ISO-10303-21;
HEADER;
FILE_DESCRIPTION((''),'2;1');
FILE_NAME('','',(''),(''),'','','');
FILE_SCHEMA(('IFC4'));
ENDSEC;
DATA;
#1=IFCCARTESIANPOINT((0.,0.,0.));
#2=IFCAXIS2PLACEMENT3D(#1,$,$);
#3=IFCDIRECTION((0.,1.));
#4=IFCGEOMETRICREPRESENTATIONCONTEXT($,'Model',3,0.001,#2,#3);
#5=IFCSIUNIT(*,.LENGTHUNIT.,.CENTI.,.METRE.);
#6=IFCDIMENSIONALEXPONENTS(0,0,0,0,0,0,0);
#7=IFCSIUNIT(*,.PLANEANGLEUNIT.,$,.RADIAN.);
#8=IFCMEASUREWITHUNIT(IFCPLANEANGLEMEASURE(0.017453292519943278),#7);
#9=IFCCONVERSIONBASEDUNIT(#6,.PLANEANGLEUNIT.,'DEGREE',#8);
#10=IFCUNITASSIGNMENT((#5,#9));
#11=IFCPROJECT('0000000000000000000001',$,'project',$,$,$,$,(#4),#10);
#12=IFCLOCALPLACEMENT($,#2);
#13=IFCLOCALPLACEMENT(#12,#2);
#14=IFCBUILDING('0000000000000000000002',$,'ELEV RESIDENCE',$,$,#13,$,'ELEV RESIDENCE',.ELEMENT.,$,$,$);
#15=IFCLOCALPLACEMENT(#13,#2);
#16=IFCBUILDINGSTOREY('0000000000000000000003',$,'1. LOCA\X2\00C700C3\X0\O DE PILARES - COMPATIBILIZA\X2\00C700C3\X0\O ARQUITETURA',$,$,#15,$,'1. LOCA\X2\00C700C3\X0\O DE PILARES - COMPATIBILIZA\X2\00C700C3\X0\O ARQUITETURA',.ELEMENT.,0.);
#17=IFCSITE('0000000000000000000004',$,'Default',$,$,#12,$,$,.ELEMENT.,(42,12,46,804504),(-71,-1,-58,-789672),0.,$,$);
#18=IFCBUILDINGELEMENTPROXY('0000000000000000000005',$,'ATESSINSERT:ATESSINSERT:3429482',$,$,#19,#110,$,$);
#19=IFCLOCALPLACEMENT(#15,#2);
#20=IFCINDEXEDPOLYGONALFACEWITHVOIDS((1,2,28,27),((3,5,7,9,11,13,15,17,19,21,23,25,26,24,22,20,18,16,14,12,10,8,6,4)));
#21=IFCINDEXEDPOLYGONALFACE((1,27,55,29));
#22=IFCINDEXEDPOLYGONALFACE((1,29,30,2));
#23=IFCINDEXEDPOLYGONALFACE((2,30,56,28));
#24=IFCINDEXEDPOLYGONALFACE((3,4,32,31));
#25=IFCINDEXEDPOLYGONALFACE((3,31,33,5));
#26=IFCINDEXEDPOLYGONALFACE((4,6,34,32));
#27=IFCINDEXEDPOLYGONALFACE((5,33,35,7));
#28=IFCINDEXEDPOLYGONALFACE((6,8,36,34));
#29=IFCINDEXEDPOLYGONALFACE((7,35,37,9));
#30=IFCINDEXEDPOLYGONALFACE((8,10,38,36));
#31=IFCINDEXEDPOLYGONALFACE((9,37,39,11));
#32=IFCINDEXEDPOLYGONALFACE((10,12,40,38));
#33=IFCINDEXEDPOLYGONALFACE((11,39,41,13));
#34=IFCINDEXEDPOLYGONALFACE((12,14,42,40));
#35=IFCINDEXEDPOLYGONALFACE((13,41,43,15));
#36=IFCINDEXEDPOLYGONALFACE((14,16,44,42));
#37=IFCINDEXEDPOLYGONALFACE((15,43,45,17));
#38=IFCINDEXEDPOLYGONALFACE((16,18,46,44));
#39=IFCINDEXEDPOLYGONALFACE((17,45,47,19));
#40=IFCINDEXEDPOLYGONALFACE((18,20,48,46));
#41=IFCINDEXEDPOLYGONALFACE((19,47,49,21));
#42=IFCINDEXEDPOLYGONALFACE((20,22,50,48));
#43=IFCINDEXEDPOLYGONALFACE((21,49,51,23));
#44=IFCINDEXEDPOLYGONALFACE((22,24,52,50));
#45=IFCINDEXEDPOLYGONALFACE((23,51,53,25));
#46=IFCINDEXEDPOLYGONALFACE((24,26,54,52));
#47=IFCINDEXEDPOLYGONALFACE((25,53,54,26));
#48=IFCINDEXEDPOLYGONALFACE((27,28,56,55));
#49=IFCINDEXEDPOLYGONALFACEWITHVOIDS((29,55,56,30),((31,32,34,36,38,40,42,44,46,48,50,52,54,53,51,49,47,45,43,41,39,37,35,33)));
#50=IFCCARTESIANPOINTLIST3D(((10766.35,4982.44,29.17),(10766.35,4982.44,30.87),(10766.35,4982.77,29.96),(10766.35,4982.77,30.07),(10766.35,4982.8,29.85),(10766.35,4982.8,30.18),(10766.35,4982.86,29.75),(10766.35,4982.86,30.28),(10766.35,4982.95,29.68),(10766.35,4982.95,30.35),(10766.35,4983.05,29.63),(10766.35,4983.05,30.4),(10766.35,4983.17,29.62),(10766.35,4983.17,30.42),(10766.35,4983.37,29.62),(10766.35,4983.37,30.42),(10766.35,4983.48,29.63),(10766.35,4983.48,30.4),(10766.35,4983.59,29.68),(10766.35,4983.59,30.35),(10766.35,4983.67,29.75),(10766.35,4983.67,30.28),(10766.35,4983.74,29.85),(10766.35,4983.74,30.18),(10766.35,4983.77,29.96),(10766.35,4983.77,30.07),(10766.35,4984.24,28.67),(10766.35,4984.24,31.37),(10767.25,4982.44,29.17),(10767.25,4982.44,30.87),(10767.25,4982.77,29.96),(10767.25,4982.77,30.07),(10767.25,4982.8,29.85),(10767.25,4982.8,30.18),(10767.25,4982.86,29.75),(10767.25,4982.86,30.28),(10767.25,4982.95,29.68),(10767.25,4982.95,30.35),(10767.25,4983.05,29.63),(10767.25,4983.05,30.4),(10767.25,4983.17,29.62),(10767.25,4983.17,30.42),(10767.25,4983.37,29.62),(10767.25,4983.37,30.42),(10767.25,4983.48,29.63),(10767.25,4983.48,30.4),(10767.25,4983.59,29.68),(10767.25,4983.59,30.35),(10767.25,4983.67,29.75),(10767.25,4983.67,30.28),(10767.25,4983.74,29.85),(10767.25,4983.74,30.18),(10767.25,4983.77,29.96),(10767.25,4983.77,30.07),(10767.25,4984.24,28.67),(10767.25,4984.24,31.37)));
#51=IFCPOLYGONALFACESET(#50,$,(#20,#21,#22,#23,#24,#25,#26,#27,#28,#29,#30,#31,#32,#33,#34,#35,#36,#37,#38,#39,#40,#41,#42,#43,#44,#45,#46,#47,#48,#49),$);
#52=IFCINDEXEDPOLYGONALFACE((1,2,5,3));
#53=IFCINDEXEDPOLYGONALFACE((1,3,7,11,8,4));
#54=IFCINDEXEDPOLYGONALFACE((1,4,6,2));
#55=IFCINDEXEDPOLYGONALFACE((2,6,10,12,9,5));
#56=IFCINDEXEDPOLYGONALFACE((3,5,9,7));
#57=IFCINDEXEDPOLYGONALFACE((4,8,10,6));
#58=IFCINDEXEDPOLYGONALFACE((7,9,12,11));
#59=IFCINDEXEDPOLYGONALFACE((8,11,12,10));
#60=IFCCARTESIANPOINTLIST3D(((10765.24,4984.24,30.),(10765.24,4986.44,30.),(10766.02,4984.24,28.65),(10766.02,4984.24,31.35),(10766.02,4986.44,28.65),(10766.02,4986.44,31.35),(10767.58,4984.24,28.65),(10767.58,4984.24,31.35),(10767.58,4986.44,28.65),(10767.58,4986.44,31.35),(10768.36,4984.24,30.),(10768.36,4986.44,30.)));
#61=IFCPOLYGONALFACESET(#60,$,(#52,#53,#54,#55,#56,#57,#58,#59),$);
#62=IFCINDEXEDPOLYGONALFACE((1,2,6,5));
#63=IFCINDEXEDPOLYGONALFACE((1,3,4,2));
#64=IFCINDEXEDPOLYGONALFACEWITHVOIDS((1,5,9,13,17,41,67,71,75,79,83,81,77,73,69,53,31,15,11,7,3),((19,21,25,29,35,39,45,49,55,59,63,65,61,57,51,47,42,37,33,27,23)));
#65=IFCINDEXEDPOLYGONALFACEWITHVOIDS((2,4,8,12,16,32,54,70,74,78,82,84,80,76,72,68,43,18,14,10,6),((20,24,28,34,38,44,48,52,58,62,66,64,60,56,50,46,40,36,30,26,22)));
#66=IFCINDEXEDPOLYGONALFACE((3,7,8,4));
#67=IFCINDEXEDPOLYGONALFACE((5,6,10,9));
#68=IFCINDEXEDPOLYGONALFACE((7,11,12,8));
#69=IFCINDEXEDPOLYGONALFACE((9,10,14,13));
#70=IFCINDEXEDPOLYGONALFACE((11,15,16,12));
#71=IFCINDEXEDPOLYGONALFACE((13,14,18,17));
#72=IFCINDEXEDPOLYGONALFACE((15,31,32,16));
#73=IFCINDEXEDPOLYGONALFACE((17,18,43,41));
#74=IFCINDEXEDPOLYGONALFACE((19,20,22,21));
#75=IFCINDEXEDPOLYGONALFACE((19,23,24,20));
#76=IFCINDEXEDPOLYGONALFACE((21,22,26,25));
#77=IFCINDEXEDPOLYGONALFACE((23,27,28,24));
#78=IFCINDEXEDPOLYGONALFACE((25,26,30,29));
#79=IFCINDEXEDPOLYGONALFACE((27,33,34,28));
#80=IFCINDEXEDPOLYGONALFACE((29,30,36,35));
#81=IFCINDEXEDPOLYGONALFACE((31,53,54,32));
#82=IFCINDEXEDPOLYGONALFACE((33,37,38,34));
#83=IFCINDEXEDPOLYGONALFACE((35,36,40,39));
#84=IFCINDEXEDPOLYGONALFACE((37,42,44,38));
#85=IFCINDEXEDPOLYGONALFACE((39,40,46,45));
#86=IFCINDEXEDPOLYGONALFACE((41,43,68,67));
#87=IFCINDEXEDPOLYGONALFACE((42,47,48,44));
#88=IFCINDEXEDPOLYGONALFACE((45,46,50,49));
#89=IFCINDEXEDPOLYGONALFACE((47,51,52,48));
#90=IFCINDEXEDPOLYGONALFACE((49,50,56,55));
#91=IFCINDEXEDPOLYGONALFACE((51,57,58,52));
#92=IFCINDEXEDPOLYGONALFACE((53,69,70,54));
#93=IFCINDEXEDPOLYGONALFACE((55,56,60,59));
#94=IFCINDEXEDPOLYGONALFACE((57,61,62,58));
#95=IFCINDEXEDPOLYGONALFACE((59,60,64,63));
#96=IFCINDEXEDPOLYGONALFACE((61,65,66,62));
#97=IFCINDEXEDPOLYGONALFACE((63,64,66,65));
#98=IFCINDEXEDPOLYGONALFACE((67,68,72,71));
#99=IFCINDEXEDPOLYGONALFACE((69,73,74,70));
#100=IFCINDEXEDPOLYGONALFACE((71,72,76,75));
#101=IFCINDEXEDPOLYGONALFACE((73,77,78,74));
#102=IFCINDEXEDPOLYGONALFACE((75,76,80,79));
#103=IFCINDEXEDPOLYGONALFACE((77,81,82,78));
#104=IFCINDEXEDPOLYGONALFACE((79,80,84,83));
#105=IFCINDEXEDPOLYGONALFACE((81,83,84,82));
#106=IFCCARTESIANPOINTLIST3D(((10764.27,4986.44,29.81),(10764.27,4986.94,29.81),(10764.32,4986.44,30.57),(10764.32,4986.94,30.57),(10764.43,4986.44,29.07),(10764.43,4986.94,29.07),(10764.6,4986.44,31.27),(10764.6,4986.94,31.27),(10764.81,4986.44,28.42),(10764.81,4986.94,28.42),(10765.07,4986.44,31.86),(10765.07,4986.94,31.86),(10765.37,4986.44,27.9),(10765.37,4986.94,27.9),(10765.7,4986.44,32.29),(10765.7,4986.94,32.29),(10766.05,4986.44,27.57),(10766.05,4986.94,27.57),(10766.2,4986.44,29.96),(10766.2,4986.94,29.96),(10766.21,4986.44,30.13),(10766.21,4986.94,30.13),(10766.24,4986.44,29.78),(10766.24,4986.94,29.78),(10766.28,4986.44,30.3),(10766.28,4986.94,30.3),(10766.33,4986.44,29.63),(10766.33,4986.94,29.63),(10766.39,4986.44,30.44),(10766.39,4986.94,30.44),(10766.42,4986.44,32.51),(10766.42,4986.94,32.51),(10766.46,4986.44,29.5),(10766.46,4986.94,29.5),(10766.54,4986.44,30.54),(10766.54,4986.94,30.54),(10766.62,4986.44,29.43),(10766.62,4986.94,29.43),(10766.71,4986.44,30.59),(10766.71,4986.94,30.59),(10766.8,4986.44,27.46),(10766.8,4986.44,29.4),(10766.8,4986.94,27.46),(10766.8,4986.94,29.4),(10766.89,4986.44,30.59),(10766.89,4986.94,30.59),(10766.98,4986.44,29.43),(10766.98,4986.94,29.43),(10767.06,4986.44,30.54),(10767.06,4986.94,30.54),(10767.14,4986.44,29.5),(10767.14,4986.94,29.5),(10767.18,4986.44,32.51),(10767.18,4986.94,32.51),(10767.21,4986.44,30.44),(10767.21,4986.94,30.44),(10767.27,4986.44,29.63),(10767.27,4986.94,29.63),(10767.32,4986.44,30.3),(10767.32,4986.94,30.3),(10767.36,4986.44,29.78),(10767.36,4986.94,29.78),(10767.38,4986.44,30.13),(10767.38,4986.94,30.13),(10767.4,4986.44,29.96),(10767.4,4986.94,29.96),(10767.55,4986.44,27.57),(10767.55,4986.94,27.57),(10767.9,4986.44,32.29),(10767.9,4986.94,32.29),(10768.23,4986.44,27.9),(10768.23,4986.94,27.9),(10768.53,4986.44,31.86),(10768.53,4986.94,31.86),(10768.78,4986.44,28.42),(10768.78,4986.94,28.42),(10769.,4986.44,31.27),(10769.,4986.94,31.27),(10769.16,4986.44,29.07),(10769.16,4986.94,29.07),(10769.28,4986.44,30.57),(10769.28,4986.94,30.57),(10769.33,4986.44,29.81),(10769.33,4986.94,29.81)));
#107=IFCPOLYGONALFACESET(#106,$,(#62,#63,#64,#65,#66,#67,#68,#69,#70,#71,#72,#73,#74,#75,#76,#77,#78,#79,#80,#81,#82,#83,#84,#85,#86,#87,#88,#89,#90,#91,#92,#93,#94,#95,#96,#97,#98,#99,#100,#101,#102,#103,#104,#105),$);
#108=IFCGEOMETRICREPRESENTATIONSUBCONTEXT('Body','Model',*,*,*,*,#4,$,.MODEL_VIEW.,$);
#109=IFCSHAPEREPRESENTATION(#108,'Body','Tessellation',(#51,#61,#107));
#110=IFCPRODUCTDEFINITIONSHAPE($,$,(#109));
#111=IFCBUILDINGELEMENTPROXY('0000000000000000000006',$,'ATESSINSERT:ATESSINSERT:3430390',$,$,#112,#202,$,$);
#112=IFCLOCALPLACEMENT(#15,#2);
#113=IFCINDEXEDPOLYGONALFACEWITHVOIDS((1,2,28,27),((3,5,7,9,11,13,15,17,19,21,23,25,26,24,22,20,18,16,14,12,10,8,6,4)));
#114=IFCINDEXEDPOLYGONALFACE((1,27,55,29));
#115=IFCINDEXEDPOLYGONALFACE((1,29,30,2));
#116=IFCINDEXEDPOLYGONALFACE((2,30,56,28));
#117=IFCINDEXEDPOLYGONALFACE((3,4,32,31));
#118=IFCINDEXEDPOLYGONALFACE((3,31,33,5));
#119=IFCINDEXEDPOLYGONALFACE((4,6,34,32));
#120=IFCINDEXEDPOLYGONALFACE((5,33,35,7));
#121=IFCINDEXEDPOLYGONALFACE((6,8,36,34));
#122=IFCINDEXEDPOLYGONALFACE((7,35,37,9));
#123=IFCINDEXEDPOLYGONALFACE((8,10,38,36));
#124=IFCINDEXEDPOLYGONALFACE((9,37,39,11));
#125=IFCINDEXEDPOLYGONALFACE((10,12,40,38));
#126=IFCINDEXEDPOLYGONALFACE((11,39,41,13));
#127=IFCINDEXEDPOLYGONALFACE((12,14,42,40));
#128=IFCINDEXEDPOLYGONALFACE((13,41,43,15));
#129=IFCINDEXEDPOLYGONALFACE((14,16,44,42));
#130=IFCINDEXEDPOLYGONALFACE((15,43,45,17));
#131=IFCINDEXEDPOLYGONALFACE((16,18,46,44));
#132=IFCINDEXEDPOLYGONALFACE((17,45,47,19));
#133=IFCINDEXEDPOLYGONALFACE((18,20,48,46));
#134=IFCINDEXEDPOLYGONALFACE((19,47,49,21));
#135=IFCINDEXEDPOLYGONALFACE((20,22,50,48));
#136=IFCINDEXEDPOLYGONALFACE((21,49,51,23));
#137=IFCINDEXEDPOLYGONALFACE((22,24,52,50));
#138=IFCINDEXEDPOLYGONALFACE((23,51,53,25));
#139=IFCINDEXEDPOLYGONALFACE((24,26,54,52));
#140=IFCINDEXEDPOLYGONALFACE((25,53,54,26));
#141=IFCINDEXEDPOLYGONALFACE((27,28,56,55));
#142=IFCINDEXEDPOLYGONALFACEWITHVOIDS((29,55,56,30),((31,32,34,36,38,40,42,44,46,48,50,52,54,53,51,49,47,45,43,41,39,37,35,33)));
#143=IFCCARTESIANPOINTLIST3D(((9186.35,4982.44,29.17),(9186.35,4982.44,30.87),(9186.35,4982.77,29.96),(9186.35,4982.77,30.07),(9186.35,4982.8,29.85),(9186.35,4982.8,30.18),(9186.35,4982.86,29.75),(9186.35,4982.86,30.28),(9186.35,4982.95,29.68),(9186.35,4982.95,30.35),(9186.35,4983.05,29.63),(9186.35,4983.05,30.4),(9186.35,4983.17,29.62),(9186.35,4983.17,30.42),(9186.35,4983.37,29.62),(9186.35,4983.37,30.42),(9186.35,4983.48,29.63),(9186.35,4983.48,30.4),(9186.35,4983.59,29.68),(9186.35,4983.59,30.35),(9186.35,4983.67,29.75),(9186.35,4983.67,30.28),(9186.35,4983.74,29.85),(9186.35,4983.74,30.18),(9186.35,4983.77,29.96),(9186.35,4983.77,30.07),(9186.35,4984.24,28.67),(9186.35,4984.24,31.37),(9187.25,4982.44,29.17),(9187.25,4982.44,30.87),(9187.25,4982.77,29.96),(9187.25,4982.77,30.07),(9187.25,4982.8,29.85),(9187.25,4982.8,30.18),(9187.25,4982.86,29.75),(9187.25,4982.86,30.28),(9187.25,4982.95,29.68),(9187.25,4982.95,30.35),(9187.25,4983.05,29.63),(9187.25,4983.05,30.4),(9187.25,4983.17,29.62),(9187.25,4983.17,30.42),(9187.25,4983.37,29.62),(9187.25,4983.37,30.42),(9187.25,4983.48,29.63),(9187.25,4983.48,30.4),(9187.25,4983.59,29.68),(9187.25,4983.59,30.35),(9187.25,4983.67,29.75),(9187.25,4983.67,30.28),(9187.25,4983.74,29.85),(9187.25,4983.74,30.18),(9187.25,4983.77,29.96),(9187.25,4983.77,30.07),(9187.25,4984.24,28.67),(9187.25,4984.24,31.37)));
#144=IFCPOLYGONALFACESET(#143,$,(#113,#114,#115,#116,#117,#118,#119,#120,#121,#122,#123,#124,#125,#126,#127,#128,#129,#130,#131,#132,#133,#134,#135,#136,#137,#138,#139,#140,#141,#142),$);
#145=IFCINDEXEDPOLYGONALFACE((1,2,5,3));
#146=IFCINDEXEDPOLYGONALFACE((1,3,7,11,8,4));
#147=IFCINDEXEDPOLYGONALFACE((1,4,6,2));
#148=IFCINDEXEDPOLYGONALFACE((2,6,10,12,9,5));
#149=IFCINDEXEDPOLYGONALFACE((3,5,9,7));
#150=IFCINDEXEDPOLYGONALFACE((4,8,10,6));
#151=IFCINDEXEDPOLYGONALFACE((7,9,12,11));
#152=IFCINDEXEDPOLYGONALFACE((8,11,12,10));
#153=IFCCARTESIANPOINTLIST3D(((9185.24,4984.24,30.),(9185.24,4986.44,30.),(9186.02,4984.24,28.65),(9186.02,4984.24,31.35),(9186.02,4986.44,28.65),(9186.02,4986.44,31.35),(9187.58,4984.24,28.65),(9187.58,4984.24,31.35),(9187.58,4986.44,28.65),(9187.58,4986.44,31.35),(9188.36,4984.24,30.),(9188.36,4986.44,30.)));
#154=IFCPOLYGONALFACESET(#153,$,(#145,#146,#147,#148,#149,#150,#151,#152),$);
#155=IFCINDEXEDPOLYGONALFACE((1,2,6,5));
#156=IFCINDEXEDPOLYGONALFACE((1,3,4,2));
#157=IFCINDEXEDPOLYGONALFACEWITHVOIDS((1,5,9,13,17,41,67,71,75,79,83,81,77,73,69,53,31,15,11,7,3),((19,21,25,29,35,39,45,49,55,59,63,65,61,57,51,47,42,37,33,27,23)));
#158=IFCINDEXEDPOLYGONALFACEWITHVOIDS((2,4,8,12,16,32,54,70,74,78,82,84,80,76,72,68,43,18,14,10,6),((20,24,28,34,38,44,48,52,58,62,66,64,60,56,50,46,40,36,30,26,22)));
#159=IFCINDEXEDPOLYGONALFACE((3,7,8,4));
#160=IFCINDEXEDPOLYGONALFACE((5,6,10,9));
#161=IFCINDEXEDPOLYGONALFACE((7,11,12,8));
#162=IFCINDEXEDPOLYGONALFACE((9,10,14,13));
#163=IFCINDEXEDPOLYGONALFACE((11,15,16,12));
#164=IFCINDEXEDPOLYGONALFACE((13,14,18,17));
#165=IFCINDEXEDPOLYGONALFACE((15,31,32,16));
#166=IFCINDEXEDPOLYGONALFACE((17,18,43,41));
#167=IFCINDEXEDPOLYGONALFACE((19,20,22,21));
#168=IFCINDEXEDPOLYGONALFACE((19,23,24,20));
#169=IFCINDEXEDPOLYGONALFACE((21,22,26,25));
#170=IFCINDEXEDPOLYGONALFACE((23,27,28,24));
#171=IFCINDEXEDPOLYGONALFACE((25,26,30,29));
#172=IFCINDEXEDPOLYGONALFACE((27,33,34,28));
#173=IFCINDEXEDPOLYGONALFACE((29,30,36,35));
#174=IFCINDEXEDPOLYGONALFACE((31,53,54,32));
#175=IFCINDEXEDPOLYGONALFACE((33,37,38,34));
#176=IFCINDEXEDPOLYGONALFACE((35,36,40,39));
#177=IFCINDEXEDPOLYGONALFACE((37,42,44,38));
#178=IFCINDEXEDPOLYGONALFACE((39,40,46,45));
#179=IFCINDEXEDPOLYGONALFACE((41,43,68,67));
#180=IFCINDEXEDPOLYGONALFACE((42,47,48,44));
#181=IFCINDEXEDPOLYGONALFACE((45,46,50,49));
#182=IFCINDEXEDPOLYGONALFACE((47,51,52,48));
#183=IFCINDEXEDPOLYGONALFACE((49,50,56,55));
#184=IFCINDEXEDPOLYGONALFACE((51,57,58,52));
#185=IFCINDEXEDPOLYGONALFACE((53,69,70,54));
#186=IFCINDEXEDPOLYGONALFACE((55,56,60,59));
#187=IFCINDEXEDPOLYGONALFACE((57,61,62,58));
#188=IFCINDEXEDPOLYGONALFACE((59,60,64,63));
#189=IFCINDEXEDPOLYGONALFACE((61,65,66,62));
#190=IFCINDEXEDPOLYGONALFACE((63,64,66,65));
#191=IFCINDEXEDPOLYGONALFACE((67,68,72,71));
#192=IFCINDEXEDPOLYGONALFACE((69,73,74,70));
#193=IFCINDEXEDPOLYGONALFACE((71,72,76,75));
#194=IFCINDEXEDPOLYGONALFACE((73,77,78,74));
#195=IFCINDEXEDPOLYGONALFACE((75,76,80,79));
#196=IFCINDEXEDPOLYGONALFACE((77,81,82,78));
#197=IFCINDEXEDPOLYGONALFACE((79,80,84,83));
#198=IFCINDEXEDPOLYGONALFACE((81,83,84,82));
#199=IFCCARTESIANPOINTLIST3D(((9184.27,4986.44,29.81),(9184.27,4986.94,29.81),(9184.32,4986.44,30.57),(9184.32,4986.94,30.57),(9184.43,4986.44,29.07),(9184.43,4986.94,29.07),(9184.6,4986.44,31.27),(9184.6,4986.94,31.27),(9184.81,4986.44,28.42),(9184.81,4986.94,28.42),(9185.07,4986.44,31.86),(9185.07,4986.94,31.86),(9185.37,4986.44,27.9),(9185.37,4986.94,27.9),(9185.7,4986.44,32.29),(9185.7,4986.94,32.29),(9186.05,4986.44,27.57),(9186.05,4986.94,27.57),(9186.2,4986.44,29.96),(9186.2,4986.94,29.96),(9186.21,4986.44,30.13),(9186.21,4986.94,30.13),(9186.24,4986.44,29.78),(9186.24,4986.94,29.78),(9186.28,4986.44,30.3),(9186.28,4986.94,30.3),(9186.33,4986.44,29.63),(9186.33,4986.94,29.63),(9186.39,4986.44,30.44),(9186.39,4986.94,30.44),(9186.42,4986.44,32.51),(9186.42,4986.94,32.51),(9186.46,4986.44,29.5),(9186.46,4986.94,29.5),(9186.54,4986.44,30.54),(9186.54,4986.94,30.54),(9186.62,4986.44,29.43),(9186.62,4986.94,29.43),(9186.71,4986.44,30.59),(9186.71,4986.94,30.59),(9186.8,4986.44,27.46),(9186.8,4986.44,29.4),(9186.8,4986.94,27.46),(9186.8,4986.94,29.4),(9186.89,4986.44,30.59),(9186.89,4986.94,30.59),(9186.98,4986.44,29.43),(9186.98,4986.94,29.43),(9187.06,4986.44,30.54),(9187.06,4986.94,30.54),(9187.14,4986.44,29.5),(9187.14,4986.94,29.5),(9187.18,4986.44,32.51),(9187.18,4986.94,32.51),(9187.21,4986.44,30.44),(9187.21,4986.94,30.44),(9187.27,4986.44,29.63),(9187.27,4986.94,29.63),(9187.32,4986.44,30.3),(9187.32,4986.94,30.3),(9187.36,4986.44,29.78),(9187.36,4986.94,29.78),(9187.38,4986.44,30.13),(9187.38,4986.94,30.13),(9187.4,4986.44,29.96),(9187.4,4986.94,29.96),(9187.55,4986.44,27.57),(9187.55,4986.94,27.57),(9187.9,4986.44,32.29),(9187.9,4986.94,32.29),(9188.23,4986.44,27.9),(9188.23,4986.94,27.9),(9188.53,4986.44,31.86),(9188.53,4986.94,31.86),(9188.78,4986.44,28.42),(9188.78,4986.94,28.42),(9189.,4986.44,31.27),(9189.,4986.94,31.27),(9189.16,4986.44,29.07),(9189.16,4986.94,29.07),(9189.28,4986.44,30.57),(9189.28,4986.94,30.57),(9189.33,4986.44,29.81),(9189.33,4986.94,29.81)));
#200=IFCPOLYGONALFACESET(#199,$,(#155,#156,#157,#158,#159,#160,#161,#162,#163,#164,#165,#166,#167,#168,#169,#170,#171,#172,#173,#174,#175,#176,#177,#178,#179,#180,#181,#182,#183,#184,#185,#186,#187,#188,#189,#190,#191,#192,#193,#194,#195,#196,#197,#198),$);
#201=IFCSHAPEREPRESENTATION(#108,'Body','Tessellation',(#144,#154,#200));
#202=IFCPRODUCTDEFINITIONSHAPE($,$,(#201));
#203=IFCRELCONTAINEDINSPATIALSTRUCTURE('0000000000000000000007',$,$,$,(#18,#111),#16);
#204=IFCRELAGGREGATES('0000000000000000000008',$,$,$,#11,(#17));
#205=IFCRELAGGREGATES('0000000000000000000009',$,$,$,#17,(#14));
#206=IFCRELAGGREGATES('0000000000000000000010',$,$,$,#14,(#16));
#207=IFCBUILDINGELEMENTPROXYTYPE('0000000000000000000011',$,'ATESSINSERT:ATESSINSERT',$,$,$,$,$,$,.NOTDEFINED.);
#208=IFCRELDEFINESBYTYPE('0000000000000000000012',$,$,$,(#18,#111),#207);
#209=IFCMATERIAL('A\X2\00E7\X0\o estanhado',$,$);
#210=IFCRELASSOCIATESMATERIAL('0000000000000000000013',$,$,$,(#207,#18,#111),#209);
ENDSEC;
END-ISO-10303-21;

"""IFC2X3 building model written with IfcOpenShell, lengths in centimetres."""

from ifc_helpers import new_model, entity, si_unit, converted_unit, direction, frame, frame_2d, origin, place, context, subcontext, project, spatial, polyline, circle_curve, parameter, trimmed, segment, composite_curve, hollow_circle, outline, extrude, source, transform, mapped, material, type_object, type_shapes, element, save


model = new_model("IFC2X3")

# Units and contexts
model_context = context("Model", 3, precision=0.001, world=origin(), true_north=direction((0.0, 1.0)))
body_context = subcontext(model_context, "Body", "Model", "MODEL_VIEW")
ifc_project = project(units=[si_unit("LENGTHUNIT", "METRE", prefix="CENTI"), converted_unit("PLANEANGLEUNIT", "DEGREE", entity("IfcPlaneAngleMeasure", 0.017453292519943278), si_unit("PLANEANGLEUNIT", "RADIAN"), dimensions=[0, 0, 0, 0, 0, 0, 0])], contexts=[model_context])

# Site, building, storey
site_placement = place(None, origin())
site = spatial("IfcSite", under=ifc_project, at=site_placement, Name="Default", CompositionType="ELEMENT", RefLatitude=(42, 12, 46, 804504), RefLongitude=(-71, -1, -58, -789672), RefElevation=0.0)
building_placement = place(site_placement, origin())
building = spatial("IfcBuilding", under=site, at=building_placement, Name="ELEV RESIDENCE", LongName="ELEV RESIDENCE", CompositionType="ELEMENT")
storey_placement = place(building_placement, origin())
storey = spatial("IfcBuildingStorey", under=building, at=storey_placement, Name="1. LOCAÇÃO DE PILARES - COMPATIBILIZAÇÃO ARQUITETURA", LongName="1. LOCAÇÃO DE PILARES - COMPATIBILIZAÇÃO ARQUITETURA", CompositionType="ELEMENT", Elevation=0.0)

# Building element proxies
ifc_material_1 = material(Name="Aço estanhado")
building_element_proxy_type_1 = type_object("IfcBuildingElementProxyType", Name="ATESSINSERT:ATESSINSERT", PredefinedType="NOTDEFINED", material=ifc_material_1)
shared_shape_1 = source(origin(), body_context, "Body", "SweptSolid", [
    extrude(outline(polyline([(-1.35, -0.9), (1.35, -0.9), (0.85, 0.9), (-0.85, 0.9), (-1.35, -0.9)]), holes=[composite_curve([segment(trimmed(circle_curve(frame_2d((0.0, 0.17), x_axis=(1.0, 0.0)), 0.4), [parameter(0.0)], [parameter(180.0)], True, "PARAMETER"), False, "CONTINUOUS"), segment(polyline([(0.4, 0.17), (0.4, -0.03)]), True, "CONTINUOUS"), segment(trimmed(circle_curve(frame_2d((0.0, -0.03), x_axis=(1.0, 0.0)), 0.4), [parameter(180.0)], [parameter(0.0)], True, "PARAMETER"), False, "CONTINUOUS"), segment(polyline([(-0.4, -0.03), (-0.4, 0.17)]), True, "CONTINUOUS")], self_intersect=False)]), frame((-1.4, -0.45, 30.02), z_axis=(0.0, 1.0, 0.0), x_axis=(0.0, 0.0, 1.0)), (0.0, 0.0, 1.0), 0.9),
    extrude(outline(polyline([(-0.78, -1.35), (0.78, -1.35), (1.56, 0.0), (0.78, 1.35), (-0.78, 1.35), (-1.56, 0.0), (-0.78, -1.35)])), frame((-4.5, 0.0, 30.0), z_axis=(1.0, 0.0, 0.0), x_axis=(0.0, 1.0, 0.0)), (0.0, 0.0, 1.0), 2.2),
    extrude(hollow_circle(Radius=2.54, WallThickness=1.94, at=frame_2d((0.0, 0.0), x_axis=(1.0, 0.0))), frame((-5.0, 0.0, 30.0), z_axis=(1.0, 0.0, 0.0), x_axis=(0.0, 0.0, -1.0)), (0.0, 0.0, 1.0), 0.5),
])
type_shapes(building_element_proxy_type_1, [shared_shape_1])
for number, where, z_axis, x_axis, name in (
    (1, (10766.8, 4981.94, 0.0), (0.0, 0.0, 1.0), (0.0, -1.0, 0.0), "ATESSINSERT:ATESSINSERT:3429482"),
    (2, (9186.8, 4981.94, 0.0), (0.0, 0.0, 1.0), (0.0, -1.0, 0.0), "ATESSINSERT:ATESSINSERT:3430390"),
):
    element("IfcBuildingElementProxy", number, at=place(storey_placement, frame(where, z_axis=z_axis, x_axis=x_axis)), inside=storey, type_object=building_element_proxy_type_1, material=ifc_material_1, Name=name, context=body_context, shape_type="MappedRepresentation", body=[
        mapped(shared_shape_1, transform((0.0, 0.0, 0.0), scale=1.0)),
    ])

save(model, "model.ifc")
